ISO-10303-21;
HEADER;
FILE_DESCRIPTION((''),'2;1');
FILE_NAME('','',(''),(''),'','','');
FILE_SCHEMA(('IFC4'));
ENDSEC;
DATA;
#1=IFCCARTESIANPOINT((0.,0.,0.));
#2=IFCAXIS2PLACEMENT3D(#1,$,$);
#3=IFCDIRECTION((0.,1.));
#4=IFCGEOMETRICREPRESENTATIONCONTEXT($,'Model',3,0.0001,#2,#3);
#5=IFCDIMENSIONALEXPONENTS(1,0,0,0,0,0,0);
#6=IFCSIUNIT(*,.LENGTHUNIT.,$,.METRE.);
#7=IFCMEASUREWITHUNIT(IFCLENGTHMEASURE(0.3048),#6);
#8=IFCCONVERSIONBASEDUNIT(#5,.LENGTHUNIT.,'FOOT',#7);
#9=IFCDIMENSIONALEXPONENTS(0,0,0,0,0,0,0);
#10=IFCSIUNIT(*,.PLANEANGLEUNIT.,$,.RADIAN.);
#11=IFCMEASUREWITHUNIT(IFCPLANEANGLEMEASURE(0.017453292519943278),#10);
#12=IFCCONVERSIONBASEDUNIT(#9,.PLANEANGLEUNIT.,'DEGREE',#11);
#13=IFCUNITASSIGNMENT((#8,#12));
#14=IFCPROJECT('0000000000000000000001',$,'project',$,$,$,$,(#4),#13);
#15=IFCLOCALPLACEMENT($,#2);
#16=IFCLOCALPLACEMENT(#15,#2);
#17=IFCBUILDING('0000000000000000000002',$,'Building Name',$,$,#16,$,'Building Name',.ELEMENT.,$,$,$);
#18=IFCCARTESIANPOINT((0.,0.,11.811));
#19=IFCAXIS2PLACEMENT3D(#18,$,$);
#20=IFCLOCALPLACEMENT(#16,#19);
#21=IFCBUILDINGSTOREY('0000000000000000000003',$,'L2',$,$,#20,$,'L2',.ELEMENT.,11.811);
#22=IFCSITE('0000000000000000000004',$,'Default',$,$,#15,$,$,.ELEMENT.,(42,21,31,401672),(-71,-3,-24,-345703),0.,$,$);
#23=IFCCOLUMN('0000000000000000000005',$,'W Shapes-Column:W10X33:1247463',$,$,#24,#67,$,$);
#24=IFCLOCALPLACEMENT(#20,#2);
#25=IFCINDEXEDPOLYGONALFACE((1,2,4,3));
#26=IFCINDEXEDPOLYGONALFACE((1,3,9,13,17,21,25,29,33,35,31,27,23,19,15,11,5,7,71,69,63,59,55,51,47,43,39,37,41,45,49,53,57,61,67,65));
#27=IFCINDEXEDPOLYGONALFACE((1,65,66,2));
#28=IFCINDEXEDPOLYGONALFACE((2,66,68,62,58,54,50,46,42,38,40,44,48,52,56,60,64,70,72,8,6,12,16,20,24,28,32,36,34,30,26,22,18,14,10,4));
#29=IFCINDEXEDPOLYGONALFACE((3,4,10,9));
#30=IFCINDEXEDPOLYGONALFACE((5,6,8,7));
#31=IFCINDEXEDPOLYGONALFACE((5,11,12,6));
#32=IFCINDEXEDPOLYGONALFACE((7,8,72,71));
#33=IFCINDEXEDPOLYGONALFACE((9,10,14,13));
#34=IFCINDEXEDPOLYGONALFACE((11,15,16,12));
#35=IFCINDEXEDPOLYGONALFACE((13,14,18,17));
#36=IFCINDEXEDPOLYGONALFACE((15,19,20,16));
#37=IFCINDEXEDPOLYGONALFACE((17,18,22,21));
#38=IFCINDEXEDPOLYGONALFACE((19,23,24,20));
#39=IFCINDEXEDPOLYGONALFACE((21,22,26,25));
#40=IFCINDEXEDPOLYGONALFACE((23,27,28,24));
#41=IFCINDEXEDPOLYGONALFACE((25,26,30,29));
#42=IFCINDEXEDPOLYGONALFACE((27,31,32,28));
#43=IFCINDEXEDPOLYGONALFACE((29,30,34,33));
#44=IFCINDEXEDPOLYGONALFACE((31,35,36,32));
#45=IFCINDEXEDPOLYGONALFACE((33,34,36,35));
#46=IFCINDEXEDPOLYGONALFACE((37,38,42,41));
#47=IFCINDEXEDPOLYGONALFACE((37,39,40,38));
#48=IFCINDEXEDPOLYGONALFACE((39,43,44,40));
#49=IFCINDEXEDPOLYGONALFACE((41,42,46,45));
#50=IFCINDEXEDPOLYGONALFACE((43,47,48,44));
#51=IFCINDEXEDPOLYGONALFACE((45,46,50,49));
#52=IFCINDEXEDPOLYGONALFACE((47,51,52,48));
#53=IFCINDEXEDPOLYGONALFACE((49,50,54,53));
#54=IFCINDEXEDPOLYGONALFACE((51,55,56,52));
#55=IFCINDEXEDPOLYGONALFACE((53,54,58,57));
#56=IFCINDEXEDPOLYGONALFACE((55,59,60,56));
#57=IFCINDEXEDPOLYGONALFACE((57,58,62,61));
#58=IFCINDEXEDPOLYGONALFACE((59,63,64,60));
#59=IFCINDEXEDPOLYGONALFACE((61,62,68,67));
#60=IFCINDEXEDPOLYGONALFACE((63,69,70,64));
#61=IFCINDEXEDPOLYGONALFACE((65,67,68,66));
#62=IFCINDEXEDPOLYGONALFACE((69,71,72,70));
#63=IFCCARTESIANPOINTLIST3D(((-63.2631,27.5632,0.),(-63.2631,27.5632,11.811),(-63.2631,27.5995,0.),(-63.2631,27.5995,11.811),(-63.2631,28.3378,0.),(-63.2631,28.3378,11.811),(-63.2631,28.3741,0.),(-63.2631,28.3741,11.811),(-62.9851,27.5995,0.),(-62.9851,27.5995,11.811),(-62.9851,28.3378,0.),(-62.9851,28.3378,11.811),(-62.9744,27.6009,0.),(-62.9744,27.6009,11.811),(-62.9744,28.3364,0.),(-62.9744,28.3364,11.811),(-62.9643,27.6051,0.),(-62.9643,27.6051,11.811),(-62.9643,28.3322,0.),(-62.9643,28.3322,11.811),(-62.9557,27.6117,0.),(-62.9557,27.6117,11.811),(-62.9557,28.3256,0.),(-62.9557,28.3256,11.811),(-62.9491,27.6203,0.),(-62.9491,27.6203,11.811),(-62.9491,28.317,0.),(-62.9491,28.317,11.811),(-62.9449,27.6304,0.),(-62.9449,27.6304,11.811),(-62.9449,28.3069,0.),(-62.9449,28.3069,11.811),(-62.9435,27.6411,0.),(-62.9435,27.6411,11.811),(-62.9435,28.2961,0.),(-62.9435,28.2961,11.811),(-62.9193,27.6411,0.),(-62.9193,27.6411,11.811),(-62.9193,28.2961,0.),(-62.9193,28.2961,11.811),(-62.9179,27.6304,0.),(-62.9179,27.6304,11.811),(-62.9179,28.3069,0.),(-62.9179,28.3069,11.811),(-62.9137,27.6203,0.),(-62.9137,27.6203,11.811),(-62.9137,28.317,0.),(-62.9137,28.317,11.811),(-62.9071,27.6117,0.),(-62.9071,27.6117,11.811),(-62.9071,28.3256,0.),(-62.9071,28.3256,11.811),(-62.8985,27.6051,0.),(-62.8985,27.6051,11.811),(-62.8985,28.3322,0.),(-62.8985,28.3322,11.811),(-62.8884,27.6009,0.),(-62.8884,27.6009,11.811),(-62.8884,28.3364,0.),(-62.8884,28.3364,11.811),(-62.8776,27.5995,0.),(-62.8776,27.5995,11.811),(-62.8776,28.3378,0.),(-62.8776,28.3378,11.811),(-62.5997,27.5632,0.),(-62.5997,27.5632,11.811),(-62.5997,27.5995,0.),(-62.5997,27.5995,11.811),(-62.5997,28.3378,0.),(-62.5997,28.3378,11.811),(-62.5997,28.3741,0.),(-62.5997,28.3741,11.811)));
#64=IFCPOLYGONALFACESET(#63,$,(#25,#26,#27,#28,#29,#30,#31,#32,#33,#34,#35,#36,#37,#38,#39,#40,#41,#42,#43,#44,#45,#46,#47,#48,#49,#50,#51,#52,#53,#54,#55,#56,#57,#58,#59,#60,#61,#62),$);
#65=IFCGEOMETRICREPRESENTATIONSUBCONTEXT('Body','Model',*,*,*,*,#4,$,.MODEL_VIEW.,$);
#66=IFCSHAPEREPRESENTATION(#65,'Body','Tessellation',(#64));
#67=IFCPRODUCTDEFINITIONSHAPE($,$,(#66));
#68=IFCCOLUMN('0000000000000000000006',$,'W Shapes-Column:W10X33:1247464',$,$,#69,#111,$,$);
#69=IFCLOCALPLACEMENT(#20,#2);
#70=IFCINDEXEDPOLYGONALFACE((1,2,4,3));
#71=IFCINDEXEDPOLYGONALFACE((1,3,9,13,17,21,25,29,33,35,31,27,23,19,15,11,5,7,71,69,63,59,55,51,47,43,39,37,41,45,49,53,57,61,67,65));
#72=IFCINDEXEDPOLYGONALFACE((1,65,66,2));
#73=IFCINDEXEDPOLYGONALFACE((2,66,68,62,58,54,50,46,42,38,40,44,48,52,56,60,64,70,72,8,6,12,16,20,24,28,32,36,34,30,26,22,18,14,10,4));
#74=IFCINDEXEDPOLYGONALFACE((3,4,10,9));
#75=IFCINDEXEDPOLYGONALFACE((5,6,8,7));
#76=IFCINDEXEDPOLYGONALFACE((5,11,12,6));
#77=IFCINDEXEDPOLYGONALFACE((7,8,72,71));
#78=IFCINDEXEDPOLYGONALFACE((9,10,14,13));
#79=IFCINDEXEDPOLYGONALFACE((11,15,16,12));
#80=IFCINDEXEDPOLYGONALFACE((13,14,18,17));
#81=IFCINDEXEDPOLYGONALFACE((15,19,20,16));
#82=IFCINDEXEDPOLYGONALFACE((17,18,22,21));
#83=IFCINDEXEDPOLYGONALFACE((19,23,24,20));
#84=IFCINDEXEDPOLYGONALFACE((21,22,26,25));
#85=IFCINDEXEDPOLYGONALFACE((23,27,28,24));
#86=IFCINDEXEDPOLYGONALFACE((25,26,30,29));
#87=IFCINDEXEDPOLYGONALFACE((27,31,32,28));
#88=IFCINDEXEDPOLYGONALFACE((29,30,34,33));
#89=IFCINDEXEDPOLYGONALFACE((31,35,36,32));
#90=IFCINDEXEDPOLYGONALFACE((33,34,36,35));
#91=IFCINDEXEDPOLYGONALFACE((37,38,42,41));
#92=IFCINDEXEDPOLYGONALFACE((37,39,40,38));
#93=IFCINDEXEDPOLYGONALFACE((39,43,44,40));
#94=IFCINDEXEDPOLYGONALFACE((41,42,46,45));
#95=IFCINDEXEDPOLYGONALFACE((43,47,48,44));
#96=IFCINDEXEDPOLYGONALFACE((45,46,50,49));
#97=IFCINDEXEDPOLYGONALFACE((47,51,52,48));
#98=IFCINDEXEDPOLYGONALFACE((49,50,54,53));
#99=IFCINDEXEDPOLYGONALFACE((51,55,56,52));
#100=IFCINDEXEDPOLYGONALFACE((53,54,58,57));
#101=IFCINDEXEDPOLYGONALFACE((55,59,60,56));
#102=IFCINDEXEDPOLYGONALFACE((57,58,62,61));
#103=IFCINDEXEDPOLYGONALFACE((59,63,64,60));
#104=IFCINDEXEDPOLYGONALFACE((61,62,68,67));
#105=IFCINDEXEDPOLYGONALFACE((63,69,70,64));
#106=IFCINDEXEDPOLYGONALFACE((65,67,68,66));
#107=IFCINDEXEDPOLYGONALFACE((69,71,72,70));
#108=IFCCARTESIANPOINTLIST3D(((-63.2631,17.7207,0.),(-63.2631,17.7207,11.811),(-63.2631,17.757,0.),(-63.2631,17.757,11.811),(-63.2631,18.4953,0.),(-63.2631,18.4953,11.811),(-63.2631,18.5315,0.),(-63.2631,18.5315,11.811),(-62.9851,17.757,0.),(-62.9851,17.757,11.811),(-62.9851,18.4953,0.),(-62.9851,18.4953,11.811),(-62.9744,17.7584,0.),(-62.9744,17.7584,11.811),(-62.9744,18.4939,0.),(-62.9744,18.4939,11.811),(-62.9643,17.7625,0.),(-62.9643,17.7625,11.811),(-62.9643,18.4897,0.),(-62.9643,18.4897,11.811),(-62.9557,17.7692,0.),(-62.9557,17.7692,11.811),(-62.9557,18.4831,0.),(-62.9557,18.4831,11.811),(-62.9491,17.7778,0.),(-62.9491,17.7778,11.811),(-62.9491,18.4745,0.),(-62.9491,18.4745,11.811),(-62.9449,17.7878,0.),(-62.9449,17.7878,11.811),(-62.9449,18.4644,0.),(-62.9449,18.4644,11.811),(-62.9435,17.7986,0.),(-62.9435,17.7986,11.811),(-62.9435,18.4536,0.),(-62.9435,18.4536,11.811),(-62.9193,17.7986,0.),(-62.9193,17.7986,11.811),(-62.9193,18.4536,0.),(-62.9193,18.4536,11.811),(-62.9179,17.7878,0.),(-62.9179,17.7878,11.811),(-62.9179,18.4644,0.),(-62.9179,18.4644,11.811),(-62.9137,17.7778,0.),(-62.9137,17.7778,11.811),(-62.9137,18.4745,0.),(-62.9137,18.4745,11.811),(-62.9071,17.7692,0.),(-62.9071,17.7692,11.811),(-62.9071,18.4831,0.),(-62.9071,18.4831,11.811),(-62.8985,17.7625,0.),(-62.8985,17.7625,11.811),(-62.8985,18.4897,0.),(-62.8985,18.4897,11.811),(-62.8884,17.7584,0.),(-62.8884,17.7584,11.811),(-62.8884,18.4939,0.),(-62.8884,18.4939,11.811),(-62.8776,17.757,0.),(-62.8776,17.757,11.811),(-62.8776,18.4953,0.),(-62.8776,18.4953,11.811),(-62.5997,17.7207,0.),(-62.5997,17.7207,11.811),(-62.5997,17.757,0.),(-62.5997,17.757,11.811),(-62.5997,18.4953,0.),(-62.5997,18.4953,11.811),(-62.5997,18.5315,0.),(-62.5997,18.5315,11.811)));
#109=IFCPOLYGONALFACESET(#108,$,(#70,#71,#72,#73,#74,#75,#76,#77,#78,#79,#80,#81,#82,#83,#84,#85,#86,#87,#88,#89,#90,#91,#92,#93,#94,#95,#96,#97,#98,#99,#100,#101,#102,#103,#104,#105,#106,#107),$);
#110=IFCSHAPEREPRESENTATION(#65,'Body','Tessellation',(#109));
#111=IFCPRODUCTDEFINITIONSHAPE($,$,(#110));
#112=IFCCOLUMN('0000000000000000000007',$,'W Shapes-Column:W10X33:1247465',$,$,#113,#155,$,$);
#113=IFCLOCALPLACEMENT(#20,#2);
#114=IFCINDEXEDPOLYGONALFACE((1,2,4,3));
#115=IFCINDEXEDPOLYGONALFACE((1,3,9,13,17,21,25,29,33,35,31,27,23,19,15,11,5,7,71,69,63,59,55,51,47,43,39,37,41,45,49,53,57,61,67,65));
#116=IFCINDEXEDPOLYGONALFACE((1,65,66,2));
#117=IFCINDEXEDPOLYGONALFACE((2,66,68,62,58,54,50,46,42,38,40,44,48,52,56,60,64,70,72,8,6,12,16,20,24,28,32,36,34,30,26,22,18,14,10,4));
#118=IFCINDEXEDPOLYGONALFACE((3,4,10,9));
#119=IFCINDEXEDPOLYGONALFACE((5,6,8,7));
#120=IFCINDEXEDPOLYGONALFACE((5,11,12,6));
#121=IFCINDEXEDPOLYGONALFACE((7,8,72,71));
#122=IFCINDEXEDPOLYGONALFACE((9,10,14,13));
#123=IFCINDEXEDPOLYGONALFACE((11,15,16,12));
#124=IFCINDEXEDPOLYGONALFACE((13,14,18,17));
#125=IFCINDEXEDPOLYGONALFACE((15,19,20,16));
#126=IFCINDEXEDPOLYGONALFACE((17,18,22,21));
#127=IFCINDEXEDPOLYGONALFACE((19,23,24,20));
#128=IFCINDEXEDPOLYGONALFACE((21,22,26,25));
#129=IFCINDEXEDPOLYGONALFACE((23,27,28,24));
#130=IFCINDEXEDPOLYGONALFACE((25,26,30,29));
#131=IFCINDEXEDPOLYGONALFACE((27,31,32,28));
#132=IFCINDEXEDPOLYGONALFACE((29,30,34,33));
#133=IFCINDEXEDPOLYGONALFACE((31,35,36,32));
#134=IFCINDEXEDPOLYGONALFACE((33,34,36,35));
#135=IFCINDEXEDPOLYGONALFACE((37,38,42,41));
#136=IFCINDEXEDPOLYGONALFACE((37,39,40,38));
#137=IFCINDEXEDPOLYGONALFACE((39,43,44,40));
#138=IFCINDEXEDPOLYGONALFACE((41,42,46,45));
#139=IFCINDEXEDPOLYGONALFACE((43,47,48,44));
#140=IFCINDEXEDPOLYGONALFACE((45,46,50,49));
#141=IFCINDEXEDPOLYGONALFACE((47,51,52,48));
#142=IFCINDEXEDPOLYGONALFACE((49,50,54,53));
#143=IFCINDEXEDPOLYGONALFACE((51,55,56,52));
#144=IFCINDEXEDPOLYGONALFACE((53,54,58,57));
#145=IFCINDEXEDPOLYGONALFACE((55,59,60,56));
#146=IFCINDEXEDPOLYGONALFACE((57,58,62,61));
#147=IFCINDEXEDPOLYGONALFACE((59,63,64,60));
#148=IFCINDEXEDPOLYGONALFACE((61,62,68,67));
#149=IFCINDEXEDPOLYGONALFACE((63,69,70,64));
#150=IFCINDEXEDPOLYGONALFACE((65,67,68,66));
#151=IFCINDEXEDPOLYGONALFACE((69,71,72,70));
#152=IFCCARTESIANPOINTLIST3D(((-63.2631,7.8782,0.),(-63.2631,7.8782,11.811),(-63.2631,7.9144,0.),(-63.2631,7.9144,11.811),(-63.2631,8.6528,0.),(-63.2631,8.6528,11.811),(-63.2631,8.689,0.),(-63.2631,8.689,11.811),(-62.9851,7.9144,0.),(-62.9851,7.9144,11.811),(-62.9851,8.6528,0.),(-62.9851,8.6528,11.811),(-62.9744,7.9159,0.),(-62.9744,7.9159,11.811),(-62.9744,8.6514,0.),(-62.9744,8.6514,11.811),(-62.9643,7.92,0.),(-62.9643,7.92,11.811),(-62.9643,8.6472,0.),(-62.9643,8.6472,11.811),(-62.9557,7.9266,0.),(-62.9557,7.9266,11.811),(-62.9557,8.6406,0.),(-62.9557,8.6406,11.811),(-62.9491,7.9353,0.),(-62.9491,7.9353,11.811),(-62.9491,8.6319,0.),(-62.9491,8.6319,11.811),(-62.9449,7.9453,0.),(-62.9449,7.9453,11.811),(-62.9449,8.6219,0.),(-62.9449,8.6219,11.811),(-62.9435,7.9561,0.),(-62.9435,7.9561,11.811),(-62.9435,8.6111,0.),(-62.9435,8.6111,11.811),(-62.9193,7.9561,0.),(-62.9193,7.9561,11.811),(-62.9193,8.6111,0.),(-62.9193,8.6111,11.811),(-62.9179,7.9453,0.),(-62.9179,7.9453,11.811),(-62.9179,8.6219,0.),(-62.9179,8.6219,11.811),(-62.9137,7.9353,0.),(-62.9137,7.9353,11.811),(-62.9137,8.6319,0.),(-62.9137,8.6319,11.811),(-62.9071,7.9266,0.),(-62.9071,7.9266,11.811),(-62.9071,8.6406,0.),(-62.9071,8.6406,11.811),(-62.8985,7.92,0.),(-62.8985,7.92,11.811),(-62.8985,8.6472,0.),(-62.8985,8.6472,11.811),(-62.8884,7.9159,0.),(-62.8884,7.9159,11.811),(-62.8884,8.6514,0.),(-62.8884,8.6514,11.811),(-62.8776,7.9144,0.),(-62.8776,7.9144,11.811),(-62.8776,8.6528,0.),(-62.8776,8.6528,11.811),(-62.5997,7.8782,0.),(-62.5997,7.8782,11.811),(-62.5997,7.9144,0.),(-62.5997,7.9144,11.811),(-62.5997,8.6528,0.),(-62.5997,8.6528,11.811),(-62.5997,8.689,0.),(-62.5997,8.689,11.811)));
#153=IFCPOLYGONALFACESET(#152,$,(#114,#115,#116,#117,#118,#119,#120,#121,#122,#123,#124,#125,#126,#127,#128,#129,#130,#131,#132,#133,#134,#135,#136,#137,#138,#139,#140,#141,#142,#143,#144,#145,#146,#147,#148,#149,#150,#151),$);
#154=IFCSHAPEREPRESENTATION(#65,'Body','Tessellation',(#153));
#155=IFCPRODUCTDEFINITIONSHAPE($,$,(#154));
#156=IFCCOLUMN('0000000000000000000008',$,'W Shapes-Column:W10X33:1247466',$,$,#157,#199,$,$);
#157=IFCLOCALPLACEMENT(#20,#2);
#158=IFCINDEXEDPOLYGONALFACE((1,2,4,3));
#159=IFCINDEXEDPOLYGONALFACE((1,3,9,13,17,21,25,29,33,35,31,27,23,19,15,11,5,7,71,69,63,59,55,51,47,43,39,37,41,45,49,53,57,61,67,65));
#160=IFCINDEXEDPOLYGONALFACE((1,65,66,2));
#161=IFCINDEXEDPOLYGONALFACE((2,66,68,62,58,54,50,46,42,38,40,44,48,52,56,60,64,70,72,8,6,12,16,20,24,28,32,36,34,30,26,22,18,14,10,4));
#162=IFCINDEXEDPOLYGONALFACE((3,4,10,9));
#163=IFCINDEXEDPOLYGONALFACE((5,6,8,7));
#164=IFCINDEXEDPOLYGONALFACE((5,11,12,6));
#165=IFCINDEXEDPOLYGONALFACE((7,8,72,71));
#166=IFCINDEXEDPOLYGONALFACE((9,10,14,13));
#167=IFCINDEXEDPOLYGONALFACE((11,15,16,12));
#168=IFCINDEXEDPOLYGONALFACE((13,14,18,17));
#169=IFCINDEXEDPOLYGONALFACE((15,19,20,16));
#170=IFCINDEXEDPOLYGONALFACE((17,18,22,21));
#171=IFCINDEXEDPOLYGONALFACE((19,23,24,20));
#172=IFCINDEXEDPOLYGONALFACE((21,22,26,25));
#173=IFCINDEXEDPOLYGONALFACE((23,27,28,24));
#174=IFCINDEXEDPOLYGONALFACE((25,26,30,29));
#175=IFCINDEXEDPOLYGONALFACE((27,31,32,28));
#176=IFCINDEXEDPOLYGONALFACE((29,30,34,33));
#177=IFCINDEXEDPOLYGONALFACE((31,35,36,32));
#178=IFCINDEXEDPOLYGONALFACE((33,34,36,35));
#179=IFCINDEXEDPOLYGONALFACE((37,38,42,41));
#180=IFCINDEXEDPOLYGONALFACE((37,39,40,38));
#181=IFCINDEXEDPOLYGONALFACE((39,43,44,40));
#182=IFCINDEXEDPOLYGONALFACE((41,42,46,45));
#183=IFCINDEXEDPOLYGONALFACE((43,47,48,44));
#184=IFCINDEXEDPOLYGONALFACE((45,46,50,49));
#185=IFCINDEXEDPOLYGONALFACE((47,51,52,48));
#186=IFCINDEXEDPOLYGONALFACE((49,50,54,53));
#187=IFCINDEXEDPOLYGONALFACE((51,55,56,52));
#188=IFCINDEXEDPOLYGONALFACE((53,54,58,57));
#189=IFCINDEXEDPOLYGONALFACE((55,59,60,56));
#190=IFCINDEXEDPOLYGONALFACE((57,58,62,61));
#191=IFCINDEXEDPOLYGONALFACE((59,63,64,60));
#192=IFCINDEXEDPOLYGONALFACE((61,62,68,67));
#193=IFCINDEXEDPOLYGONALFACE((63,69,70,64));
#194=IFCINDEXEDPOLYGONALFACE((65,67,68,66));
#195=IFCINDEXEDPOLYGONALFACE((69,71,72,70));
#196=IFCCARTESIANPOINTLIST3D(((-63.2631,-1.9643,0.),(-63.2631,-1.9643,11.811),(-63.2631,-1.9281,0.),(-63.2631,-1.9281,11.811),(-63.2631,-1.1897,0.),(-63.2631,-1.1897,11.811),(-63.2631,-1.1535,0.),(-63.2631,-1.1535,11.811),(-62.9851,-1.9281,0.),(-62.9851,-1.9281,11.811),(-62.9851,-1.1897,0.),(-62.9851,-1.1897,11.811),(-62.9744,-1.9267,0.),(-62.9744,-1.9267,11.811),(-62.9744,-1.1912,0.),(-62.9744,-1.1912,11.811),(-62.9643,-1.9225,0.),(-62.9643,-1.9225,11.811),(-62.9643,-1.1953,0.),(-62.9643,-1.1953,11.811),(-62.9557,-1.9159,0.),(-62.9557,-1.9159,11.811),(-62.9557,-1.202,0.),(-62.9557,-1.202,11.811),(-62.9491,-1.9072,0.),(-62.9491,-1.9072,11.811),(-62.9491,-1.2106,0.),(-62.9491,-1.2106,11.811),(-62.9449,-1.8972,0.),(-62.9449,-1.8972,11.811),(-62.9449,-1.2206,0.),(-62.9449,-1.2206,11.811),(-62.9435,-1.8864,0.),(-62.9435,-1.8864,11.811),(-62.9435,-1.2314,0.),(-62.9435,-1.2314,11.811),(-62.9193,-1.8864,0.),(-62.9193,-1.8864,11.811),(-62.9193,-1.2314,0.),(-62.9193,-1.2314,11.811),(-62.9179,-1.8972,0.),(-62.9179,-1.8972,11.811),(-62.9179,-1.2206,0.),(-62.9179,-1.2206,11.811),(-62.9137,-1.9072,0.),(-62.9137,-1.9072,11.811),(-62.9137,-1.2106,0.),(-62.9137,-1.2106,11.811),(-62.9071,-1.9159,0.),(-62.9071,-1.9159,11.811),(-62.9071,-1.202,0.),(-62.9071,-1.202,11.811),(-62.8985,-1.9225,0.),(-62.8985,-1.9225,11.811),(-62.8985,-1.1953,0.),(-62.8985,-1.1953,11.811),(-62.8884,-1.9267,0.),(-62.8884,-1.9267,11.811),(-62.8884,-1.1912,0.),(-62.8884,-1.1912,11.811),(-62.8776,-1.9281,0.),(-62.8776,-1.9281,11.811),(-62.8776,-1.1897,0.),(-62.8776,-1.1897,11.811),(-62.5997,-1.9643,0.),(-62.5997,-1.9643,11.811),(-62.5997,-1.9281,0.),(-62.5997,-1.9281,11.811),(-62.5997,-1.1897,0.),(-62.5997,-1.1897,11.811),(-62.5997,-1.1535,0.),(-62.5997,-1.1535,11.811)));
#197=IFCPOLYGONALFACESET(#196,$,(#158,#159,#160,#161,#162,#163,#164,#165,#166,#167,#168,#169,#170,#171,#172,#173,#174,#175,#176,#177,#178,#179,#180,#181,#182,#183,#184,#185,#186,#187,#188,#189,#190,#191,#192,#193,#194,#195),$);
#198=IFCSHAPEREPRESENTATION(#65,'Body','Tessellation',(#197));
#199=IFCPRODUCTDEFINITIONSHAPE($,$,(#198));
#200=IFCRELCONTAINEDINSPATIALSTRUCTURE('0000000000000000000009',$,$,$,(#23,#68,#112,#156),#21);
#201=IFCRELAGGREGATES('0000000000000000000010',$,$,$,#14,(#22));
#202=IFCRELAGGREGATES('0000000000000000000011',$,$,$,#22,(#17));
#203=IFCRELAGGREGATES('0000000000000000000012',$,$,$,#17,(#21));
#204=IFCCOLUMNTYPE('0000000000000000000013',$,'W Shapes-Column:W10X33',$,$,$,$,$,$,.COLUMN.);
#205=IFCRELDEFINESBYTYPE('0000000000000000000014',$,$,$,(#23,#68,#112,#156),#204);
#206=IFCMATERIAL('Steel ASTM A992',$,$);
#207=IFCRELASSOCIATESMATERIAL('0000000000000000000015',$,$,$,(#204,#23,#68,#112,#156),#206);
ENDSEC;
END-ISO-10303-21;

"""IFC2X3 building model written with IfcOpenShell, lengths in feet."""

from ifc_helpers import new_model, entity, si_unit, converted_unit, direction, frame, frame_2d, origin, place, context, subcontext, project, spatial, i_section, extrude, source, transform, mapped, material, type_object, type_shapes, element, save


model = new_model("IFC2X3")

# Units and contexts
model_context = context("Model", 3, precision=0.0001, world=origin(), true_north=direction((0.0, 1.0)))
body_context = subcontext(model_context, "Body", "Model", "MODEL_VIEW")
ifc_project = project(units=[converted_unit("LENGTHUNIT", "FOOT", entity("IfcLengthMeasure", 0.3048), si_unit("LENGTHUNIT", "METRE"), dimensions=[1, 0, 0, 0, 0, 0, 0]), converted_unit("PLANEANGLEUNIT", "DEGREE", entity("IfcPlaneAngleMeasure", 0.017453292519943278), si_unit("PLANEANGLEUNIT", "RADIAN"), dimensions=[0, 0, 0, 0, 0, 0, 0])], contexts=[model_context])

# Site, building, storey
site_placement = place(None, origin())
site = spatial("IfcSite", under=ifc_project, at=site_placement, Name="Default", CompositionType="ELEMENT", RefLatitude=(42, 21, 31, 401672), RefLongitude=(-71, -3, -24, -345703), RefElevation=0.0)
building_placement = place(site_placement, origin())
building = spatial("IfcBuilding", under=site, at=building_placement, Name="Building Name", LongName="Building Name", CompositionType="ELEMENT")
storey_placement = place(building_placement, frame((0.0, 0.0, 11.811)))
storey = spatial("IfcBuildingStorey", under=building, at=storey_placement, Name="L2", LongName="L2", CompositionType="ELEMENT", Elevation=11.811)

# Columns
ifc_material_1 = material(Name="Steel ASTM A992")
column_type = type_object("IfcColumnType", Name="W Shapes-Column:W10X33", PredefinedType="COLUMN", material=ifc_material_1)
shared_shape = source(origin(), body_context, "Body", "SweptSolid", [
    extrude(i_section(OverallWidth=0.6633, OverallDepth=0.8108, WebThickness=0.0242, FlangeThickness=0.0362, FilletRadius=0.0417, at=frame_2d((0.0, 0.0), x_axis=(1.0, 0.0))), frame((0.0, 0.0, 11.811), z_axis=(0.0, 0.0, 1.0), x_axis=(-1.0, 0.0, 0.0)), (0.0, 0.0, 1.0), 11.811),
])
type_shapes(column_type, [shared_shape])
for number, where, name in (
    (1, (-62.9314, 27.9686, -11.811), "W Shapes-Column:W10X33:1247463"),
    (2, (-62.9314, 18.1261, -11.811), "W Shapes-Column:W10X33:1247464"),
    (3, (-62.9314, 8.2836, -11.811), "W Shapes-Column:W10X33:1247465"),
    (4, (-62.9314, -1.5589, -11.811), "W Shapes-Column:W10X33:1247466"),
):
    element("IfcColumn", number, at=place(storey_placement, frame(where)), inside=storey, type_object=column_type, material=ifc_material_1, Name=name, context=body_context, shape_type="MappedRepresentation", body=[
        mapped(shared_shape, transform((0.0, 0.0, 0.0), scale=1.0)),
    ])

save(model, "model.ifc")
